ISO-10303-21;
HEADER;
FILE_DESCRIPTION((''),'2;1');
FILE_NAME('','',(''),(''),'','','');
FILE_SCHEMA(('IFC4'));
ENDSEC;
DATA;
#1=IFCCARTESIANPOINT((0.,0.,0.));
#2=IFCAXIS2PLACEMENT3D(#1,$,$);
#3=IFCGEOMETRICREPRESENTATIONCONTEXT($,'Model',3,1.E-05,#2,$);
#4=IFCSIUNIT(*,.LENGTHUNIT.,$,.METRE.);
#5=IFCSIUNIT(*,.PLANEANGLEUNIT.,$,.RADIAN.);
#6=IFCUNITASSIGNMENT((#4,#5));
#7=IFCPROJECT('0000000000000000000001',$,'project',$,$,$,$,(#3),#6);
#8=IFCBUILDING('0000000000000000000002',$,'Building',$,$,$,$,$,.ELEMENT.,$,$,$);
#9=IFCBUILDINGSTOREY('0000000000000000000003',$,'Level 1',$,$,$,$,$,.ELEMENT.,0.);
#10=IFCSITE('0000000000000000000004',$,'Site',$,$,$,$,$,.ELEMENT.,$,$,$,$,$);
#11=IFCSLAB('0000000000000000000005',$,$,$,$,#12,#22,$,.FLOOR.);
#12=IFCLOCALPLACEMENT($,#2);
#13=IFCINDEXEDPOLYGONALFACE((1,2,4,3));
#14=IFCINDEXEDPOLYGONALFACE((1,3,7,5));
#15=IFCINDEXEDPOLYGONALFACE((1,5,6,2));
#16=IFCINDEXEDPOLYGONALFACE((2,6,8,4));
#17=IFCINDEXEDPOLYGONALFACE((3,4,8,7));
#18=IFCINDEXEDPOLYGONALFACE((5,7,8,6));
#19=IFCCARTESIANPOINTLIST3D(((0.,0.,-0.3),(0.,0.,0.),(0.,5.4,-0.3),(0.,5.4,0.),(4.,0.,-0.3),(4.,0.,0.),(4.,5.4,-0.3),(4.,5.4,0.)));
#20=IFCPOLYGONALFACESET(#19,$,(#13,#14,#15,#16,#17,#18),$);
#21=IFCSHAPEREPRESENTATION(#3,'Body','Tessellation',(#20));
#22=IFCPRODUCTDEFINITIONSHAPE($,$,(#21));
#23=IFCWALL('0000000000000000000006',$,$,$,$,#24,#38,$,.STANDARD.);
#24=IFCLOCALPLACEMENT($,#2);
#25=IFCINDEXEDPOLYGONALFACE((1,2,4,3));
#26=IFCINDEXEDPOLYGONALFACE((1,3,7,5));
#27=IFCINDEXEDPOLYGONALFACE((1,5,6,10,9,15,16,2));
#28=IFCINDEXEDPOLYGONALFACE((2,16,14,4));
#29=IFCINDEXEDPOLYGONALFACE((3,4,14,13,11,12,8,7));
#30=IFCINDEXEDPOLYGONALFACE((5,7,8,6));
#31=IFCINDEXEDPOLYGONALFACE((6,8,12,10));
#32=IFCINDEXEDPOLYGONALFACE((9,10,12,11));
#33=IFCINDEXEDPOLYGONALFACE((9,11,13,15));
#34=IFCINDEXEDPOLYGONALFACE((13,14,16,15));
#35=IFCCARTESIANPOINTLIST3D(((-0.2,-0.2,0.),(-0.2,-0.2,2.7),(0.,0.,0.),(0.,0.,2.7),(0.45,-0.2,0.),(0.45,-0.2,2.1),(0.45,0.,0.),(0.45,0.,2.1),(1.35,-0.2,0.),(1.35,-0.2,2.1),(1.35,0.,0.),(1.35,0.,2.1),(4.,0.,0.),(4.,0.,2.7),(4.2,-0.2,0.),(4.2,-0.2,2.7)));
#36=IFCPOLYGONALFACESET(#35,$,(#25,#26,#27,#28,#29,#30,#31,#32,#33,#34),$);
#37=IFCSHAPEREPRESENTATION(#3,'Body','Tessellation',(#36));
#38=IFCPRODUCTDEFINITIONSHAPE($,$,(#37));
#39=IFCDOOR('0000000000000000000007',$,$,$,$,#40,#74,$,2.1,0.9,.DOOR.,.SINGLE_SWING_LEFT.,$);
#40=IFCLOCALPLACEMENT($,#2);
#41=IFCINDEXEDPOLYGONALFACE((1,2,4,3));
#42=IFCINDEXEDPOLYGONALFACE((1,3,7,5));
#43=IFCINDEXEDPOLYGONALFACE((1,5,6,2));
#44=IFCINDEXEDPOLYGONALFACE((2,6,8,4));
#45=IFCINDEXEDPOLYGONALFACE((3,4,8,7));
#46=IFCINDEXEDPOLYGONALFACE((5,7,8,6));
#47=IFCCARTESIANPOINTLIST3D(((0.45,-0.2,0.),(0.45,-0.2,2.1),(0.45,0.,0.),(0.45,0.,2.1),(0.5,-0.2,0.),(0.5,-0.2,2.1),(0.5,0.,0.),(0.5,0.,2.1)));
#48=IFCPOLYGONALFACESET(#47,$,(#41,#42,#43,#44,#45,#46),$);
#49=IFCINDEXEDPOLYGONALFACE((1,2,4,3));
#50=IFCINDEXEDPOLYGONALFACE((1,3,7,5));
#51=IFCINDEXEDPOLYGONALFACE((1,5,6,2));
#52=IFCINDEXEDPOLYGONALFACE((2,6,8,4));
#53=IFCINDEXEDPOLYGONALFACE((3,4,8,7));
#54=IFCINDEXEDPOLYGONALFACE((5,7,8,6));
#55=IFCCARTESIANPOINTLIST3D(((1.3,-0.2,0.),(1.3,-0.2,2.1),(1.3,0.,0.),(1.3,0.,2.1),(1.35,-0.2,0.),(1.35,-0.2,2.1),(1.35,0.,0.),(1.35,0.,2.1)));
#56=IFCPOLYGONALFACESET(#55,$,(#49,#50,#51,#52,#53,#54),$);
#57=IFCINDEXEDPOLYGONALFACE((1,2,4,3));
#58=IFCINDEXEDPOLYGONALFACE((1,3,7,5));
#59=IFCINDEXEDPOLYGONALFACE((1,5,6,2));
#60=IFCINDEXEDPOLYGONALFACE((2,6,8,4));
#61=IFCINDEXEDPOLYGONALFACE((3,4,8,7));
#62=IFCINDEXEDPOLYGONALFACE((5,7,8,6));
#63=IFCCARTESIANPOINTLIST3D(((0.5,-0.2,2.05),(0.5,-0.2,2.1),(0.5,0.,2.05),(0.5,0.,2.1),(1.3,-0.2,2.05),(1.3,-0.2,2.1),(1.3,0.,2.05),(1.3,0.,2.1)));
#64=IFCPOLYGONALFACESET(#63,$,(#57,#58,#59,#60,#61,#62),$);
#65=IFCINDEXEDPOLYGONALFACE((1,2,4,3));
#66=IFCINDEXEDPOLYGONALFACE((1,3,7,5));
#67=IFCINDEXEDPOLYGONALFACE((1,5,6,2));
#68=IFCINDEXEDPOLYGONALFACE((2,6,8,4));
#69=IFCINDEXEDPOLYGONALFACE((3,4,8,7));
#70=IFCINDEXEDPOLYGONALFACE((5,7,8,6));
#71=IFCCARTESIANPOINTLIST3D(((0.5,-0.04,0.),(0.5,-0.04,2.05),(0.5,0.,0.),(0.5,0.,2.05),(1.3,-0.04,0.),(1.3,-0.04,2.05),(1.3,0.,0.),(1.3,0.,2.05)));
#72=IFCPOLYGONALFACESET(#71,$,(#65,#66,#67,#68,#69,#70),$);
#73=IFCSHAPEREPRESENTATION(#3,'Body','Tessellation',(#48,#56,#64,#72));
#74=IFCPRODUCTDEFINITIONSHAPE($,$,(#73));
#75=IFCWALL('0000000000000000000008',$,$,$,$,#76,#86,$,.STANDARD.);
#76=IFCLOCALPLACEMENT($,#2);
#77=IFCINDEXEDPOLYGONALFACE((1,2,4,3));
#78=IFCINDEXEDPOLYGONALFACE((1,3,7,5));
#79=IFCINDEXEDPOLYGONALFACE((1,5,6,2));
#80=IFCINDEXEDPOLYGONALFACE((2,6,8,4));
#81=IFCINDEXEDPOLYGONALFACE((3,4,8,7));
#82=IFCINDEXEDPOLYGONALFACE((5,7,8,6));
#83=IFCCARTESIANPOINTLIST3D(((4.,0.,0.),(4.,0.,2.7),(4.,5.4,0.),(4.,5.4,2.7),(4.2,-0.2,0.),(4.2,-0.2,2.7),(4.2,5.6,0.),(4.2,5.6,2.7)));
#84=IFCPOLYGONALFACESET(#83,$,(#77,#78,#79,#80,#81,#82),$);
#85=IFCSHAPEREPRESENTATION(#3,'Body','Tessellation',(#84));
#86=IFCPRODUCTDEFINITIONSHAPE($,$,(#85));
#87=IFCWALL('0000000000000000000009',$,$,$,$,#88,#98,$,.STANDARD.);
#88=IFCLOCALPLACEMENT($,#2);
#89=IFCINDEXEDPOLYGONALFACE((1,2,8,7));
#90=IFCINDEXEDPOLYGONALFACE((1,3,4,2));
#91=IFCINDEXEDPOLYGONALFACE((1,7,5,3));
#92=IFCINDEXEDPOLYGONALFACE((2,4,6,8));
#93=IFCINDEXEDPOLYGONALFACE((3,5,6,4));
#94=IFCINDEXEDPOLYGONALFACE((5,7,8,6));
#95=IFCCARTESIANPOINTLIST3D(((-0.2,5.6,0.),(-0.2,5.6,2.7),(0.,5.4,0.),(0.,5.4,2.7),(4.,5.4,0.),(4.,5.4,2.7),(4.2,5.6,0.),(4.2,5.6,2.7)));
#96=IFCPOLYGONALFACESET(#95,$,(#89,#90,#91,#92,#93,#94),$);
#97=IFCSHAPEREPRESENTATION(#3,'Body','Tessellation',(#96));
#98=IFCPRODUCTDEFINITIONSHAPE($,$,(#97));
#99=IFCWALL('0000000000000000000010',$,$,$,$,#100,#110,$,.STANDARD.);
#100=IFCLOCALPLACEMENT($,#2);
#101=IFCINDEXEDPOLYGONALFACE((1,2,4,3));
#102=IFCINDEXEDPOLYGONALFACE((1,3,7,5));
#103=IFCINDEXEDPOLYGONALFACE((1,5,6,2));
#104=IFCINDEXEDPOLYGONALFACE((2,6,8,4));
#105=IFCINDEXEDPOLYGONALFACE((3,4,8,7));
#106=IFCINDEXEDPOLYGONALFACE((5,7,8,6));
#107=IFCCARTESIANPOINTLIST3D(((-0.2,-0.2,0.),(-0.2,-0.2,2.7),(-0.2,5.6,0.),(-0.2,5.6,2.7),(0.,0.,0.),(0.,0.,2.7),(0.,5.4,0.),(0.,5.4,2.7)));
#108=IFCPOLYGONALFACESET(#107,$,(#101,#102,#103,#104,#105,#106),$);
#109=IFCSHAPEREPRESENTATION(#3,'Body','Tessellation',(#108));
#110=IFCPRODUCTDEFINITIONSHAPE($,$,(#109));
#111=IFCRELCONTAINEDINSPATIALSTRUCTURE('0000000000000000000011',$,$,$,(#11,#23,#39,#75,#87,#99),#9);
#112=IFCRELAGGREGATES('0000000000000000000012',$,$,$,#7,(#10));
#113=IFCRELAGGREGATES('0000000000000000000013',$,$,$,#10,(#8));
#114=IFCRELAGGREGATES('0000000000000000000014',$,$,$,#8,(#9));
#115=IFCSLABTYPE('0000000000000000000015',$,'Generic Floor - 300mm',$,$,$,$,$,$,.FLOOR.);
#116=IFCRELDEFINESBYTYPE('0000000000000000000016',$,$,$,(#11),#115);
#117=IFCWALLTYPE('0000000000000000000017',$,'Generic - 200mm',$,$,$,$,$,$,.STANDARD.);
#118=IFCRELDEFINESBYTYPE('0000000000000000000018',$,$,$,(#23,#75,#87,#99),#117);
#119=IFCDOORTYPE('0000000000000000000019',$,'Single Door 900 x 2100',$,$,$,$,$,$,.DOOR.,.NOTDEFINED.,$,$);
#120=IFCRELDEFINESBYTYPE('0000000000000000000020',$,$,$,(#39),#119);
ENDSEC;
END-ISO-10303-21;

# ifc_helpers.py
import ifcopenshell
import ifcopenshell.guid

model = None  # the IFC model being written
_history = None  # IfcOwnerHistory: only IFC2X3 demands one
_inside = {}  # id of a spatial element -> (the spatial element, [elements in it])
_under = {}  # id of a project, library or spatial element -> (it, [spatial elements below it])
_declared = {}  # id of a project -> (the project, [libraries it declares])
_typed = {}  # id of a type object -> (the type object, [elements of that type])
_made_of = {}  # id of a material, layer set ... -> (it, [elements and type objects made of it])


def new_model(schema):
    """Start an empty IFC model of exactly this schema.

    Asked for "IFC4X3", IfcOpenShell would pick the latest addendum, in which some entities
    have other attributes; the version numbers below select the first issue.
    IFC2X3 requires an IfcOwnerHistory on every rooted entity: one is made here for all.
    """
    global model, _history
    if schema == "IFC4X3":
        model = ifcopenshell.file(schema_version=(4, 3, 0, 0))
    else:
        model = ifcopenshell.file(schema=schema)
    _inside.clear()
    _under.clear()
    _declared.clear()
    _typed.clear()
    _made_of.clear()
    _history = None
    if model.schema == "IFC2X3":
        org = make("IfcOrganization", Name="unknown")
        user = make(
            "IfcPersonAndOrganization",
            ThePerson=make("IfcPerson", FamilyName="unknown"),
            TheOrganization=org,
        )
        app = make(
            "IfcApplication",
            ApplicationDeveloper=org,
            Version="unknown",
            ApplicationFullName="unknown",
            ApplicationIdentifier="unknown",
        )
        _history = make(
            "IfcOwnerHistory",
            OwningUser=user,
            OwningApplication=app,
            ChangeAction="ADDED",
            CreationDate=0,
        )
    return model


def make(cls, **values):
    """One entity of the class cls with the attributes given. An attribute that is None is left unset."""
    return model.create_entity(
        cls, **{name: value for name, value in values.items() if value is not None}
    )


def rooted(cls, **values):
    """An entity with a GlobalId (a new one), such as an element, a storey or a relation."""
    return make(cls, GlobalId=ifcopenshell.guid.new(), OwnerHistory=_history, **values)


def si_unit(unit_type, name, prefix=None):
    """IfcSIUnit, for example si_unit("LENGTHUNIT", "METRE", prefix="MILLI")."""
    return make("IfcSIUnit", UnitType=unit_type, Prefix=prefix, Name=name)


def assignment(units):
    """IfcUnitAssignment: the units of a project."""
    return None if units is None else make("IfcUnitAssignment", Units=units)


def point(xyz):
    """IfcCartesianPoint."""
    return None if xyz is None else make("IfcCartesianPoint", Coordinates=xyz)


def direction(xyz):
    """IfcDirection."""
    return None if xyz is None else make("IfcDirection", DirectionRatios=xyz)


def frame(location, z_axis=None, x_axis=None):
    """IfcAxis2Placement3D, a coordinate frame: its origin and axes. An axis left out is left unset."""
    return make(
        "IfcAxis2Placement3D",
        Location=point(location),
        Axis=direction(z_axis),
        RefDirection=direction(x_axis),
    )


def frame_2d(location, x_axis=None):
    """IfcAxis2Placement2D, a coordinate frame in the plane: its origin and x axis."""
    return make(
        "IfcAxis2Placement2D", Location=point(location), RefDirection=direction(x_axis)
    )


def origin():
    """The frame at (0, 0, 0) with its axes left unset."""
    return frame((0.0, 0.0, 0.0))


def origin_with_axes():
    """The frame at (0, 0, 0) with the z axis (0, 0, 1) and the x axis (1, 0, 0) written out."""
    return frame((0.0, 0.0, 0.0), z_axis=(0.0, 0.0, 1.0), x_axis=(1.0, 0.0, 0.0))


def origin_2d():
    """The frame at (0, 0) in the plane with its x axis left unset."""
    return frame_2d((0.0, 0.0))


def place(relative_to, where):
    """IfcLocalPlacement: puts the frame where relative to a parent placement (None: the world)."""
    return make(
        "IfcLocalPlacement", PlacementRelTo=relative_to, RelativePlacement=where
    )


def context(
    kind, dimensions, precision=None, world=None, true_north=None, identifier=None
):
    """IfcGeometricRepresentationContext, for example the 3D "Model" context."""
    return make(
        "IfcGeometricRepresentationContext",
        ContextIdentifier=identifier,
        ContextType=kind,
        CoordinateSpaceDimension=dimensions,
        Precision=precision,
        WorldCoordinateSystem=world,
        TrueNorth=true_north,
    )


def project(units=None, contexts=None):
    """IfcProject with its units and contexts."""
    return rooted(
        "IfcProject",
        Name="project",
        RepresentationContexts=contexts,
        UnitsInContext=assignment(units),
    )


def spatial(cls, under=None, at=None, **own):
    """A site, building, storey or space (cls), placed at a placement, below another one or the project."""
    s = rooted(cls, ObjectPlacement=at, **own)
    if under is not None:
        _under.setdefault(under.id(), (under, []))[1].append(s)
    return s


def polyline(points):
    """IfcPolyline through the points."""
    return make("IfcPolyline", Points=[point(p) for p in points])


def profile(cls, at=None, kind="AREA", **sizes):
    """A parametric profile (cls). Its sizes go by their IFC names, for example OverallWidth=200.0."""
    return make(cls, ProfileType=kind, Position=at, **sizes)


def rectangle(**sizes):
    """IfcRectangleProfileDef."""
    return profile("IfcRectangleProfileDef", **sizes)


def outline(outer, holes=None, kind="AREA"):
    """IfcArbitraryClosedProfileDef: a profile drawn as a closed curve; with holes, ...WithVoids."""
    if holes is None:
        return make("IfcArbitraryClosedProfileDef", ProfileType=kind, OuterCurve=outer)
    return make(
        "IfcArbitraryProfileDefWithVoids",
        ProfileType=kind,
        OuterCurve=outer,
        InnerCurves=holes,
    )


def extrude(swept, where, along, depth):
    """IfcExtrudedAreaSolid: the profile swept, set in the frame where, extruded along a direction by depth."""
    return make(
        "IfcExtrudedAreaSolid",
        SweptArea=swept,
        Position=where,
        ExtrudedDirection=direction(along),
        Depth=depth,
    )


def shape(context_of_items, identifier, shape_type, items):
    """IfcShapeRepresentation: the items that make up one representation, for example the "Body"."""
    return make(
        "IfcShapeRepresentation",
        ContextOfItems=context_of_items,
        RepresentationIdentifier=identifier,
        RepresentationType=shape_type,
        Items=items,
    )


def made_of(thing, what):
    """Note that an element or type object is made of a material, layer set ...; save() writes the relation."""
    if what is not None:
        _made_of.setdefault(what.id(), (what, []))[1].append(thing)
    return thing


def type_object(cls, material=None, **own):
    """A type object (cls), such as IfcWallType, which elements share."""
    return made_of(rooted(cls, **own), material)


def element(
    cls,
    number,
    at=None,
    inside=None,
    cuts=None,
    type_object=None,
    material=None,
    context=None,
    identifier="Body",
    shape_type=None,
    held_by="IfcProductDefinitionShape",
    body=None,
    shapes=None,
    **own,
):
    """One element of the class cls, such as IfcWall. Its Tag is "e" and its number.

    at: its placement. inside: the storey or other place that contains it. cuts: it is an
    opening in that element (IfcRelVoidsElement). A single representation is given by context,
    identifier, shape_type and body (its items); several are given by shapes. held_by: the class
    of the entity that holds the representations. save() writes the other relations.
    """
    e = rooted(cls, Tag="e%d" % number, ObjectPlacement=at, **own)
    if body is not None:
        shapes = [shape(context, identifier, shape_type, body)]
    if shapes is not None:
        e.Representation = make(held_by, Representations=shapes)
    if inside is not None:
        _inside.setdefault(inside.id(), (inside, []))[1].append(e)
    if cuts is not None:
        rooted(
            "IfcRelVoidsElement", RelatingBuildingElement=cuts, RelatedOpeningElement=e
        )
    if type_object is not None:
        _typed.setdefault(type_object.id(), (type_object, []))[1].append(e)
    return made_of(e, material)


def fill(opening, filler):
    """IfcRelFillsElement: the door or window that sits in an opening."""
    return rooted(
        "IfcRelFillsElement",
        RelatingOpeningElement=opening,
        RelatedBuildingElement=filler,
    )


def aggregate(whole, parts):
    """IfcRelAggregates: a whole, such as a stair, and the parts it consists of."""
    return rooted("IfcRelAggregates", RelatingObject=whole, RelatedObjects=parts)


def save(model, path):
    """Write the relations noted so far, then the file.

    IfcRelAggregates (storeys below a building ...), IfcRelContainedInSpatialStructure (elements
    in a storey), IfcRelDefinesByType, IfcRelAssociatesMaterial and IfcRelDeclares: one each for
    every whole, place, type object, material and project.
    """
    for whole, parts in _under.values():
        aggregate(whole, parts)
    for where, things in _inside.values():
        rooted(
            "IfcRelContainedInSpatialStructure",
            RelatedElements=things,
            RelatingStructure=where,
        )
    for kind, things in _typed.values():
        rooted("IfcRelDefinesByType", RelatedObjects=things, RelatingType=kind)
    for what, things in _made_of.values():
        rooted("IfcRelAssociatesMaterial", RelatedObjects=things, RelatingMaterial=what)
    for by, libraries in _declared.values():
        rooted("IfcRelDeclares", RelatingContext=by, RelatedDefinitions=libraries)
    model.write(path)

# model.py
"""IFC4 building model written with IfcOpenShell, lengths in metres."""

from ifc_helpers import new_model, si_unit, frame, frame_2d, origin, origin_with_axes, origin_2d, place, context, project, spatial, polyline, rectangle, outline, extrude, type_object, element, fill, save


model = new_model("IFC4")

# Units and contexts
model_context = context("Model", 3, precision=1e-05, world=origin())
ifc_project = project(units=[si_unit("LENGTHUNIT", "METRE"), si_unit("PLANEANGLEUNIT", "RADIAN")], contexts=[model_context])

# Site, building, storey
site = spatial("IfcSite", under=ifc_project, Name="Site", CompositionType="ELEMENT")
building = spatial("IfcBuilding", under=site, Name="Building", CompositionType="ELEMENT")
storey = spatial("IfcBuildingStorey", under=building, Name="Level 1", CompositionType="ELEMENT", Elevation=0.0)

# Slab
slab_type = type_object("IfcSlabType", Name="Generic Floor - 300mm", PredefinedType="FLOOR")
slab_placement = place(None, origin())
element("IfcSlab", 1, at=slab_placement, inside=storey, type_object=slab_type, PredefinedType="FLOOR", context=model_context, shape_type="SweptSolid", body=[
    extrude(outline(polyline([(0.0, 0.0), (4.0, 0.0), (4.0, 5.4), (0.0, 5.4), (0.0, 0.0)])), origin(), (0.0, 0.0, -1.0), 0.3),
])

# Wall, opening, door
wall_type = type_object("IfcWallType", Name="Generic - 200mm", PredefinedType="STANDARD")
wall_1_placement = place(None, frame((-0.1, -0.1, 0.0), z_axis=(0.0, 0.0, 1.0), x_axis=(1.0, 0.0, 0.0)))
wall_1 = element("IfcWall", 2, at=wall_1_placement, inside=storey, type_object=wall_type, PredefinedType="STANDARD", context=model_context, shape_type="SweptSolid", body=[
    extrude(outline(polyline([(-0.1, -0.1), (4.3, -0.1), (4.1, 0.1), (0.1, 0.1), (-0.1, -0.1)])), origin(), (0.0, 0.0, 1.0), 2.7),
])
opening_placement = place(wall_1_placement, frame((1.0, 0.0, 0.0), z_axis=(0.0, 0.0, 1.0), x_axis=(1.0, 0.0, 0.0)))
opening = element("IfcOpeningElement", 3, at=opening_placement, cuts=wall_1, PredefinedType="OPENING", context=model_context, shape_type="SweptSolid", body=[
    extrude(rectangle(XDim=0.9, YDim=0.202, at=origin_2d()), origin(), (0.0, 0.0, 1.0), 2.1),
])
door_type = type_object("IfcDoorType", Name="Single Door 900 x 2100", OperationType="NOTDEFINED", PredefinedType="DOOR")
door_placement = place(opening_placement, origin_with_axes())
door = element("IfcDoor", 4, at=door_placement, inside=storey, type_object=door_type, OperationType="SINGLE_SWING_LEFT", OverallHeight=2.1, OverallWidth=0.9, PredefinedType="DOOR", context=model_context, shape_type="SweptSolid", body=[
    extrude(rectangle(XDim=0.05, YDim=0.2, at=frame_2d((-0.425, 0.0))), origin(), (0.0, 0.0, 1.0), 2.1),
    extrude(rectangle(XDim=0.05, YDim=0.2, at=frame_2d((0.425, 0.0))), origin(), (0.0, 0.0, 1.0), 2.1),
    extrude(rectangle(XDim=0.8, YDim=0.2, at=origin_2d()), frame((0.0, 0.0, 2.05)), (0.0, 0.0, 1.0), 0.05),
    extrude(rectangle(XDim=0.8, YDim=0.04, at=frame_2d((0.0, 0.08))), origin(), (0.0, 0.0, 1.0), 2.05),
])
fill(opening, door)

# Walls
wall_2_placement = place(None, frame((4.1, -0.1, 0.0), z_axis=(0.0, 0.0, 1.0), x_axis=(0.0, 1.0, 0.0)))
element("IfcWall", 5, at=wall_2_placement, inside=storey, type_object=wall_type, PredefinedType="STANDARD", context=model_context, shape_type="SweptSolid", body=[
    extrude(outline(polyline([(-0.1, -0.1), (5.7, -0.1), (5.5, 0.1), (0.1, 0.1), (-0.1, -0.1)])), origin(), (0.0, 0.0, 1.0), 2.7),
])
wall_3_placement = place(None, frame((4.1, 5.5, 0.0), z_axis=(0.0, 0.0, 1.0), x_axis=(-1.0, 0.0, 0.0)))
element("IfcWall", 6, at=wall_3_placement, inside=storey, type_object=wall_type, PredefinedType="STANDARD", context=model_context, shape_type="SweptSolid", body=[
    extrude(outline(polyline([(-0.1, -0.1), (4.3, -0.1), (4.1, 0.1), (0.1, 0.1), (-0.1, -0.1)])), origin(), (0.0, 0.0, 1.0), 2.7),
])
wall_4_placement = place(None, frame((-0.1, 5.5, 0.0), z_axis=(0.0, 0.0, 1.0), x_axis=(0.0, -1.0, 0.0)))
element("IfcWall", 7, at=wall_4_placement, inside=storey, type_object=wall_type, PredefinedType="STANDARD", context=model_context, shape_type="SweptSolid", body=[
    extrude(outline(polyline([(-0.1, -0.1), (5.7, -0.1), (5.5, 0.1), (0.1, 0.1), (-0.1, -0.1)])), origin(), (0.0, 0.0, 1.0), 2.7),
])

save(model, "model.ifc")
